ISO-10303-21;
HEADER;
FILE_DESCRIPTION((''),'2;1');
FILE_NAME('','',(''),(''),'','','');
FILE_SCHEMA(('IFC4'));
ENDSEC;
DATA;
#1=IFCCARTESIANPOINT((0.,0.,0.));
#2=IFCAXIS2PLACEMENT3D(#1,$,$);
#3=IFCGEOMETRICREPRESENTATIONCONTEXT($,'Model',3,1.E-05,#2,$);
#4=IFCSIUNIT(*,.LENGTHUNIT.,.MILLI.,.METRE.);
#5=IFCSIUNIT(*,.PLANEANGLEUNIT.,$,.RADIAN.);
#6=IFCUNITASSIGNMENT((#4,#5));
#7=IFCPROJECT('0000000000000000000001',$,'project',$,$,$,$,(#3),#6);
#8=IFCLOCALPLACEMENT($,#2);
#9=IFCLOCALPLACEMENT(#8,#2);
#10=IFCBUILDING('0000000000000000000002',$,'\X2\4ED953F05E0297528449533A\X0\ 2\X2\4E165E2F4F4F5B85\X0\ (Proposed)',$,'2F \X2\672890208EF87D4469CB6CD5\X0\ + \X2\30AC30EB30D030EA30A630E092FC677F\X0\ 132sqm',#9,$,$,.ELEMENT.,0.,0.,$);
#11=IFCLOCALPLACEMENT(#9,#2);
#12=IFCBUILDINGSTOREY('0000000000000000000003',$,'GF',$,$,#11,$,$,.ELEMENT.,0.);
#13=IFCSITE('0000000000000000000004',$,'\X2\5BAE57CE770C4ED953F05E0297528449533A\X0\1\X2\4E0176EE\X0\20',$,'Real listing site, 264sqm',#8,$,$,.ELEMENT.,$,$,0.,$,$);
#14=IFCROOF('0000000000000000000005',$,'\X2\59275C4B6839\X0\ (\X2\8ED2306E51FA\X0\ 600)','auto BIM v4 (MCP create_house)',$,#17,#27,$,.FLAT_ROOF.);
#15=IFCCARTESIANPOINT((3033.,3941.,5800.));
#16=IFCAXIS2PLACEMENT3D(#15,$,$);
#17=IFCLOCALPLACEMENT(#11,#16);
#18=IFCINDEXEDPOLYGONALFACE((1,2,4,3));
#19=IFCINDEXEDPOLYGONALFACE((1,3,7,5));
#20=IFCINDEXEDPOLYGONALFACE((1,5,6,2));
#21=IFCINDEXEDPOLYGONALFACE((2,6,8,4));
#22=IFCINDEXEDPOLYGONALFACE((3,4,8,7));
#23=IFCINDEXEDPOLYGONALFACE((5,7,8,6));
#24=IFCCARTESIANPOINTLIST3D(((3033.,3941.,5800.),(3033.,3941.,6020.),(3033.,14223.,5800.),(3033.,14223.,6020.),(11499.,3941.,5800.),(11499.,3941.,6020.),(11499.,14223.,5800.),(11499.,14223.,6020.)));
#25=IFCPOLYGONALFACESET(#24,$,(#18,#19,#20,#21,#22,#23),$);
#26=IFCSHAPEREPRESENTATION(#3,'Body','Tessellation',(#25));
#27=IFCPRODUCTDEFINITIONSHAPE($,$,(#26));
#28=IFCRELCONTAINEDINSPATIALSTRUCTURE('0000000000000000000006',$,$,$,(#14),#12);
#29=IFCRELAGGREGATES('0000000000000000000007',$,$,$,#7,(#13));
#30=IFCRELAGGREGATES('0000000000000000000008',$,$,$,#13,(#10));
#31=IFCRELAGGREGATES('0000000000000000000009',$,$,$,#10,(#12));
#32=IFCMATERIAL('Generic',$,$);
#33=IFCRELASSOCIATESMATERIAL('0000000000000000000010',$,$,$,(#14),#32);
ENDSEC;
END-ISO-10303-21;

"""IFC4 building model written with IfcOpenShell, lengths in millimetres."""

from ifc_helpers import new_model, si_unit, frame, frame_2d, origin, place, context, project, spatial, rectangle, extrude, material, element, save


model = new_model("IFC4")

# Units and contexts
model_context = context("Model", 3, precision=1e-05, world=origin())
ifc_project = project(units=[si_unit("LENGTHUNIT", "METRE", prefix="MILLI"), si_unit("PLANEANGLEUNIT", "RADIAN")], contexts=[model_context])

# Site, building, storey
site_placement = place(None, origin())
site = spatial("IfcSite", under=ifc_project, at=site_placement, Name="宮城県仙台市青葉区1丁目20", ObjectType="Real listing site, 264sqm", CompositionType="ELEMENT", RefElevation=0.0)
building_placement = place(site_placement, origin())
building = spatial("IfcBuilding", under=site, at=building_placement, Name="仙台市青葉区 2世帯住宅 (Proposed)", ObjectType="2F 木造軸組構法 + ガルバリウム鋼板 132sqm", CompositionType="ELEMENT", ElevationOfRefHeight=0.0, ElevationOfTerrain=0.0)
storey_placement = place(building_placement, origin())
storey = spatial("IfcBuildingStorey", under=building, at=storey_placement, Name="GF", CompositionType="ELEMENT", Elevation=0.0)

# Shared definitions
ifc_material = material(Name="Generic")

# Roof
roof_placement = place(storey_placement, frame((3033.0, 3941.0, 5800.0)))
element("IfcRoof", 1, at=roof_placement, inside=storey, material=ifc_material, Name="大屋根 (軒の出 600)", Description="auto BIM v4 (MCP create_house)", PredefinedType="FLAT_ROOF", context=model_context, shape_type="SweptSolid", body=[
    extrude(rectangle(XDim=8466.0, YDim=10282.0, at=frame_2d((4233.0, 5141.0))), frame((3033.0, 3941.0, 5800.0)), (0.0, 0.0, 1.0), 220.0),
])

save(model, "model.ifc")
